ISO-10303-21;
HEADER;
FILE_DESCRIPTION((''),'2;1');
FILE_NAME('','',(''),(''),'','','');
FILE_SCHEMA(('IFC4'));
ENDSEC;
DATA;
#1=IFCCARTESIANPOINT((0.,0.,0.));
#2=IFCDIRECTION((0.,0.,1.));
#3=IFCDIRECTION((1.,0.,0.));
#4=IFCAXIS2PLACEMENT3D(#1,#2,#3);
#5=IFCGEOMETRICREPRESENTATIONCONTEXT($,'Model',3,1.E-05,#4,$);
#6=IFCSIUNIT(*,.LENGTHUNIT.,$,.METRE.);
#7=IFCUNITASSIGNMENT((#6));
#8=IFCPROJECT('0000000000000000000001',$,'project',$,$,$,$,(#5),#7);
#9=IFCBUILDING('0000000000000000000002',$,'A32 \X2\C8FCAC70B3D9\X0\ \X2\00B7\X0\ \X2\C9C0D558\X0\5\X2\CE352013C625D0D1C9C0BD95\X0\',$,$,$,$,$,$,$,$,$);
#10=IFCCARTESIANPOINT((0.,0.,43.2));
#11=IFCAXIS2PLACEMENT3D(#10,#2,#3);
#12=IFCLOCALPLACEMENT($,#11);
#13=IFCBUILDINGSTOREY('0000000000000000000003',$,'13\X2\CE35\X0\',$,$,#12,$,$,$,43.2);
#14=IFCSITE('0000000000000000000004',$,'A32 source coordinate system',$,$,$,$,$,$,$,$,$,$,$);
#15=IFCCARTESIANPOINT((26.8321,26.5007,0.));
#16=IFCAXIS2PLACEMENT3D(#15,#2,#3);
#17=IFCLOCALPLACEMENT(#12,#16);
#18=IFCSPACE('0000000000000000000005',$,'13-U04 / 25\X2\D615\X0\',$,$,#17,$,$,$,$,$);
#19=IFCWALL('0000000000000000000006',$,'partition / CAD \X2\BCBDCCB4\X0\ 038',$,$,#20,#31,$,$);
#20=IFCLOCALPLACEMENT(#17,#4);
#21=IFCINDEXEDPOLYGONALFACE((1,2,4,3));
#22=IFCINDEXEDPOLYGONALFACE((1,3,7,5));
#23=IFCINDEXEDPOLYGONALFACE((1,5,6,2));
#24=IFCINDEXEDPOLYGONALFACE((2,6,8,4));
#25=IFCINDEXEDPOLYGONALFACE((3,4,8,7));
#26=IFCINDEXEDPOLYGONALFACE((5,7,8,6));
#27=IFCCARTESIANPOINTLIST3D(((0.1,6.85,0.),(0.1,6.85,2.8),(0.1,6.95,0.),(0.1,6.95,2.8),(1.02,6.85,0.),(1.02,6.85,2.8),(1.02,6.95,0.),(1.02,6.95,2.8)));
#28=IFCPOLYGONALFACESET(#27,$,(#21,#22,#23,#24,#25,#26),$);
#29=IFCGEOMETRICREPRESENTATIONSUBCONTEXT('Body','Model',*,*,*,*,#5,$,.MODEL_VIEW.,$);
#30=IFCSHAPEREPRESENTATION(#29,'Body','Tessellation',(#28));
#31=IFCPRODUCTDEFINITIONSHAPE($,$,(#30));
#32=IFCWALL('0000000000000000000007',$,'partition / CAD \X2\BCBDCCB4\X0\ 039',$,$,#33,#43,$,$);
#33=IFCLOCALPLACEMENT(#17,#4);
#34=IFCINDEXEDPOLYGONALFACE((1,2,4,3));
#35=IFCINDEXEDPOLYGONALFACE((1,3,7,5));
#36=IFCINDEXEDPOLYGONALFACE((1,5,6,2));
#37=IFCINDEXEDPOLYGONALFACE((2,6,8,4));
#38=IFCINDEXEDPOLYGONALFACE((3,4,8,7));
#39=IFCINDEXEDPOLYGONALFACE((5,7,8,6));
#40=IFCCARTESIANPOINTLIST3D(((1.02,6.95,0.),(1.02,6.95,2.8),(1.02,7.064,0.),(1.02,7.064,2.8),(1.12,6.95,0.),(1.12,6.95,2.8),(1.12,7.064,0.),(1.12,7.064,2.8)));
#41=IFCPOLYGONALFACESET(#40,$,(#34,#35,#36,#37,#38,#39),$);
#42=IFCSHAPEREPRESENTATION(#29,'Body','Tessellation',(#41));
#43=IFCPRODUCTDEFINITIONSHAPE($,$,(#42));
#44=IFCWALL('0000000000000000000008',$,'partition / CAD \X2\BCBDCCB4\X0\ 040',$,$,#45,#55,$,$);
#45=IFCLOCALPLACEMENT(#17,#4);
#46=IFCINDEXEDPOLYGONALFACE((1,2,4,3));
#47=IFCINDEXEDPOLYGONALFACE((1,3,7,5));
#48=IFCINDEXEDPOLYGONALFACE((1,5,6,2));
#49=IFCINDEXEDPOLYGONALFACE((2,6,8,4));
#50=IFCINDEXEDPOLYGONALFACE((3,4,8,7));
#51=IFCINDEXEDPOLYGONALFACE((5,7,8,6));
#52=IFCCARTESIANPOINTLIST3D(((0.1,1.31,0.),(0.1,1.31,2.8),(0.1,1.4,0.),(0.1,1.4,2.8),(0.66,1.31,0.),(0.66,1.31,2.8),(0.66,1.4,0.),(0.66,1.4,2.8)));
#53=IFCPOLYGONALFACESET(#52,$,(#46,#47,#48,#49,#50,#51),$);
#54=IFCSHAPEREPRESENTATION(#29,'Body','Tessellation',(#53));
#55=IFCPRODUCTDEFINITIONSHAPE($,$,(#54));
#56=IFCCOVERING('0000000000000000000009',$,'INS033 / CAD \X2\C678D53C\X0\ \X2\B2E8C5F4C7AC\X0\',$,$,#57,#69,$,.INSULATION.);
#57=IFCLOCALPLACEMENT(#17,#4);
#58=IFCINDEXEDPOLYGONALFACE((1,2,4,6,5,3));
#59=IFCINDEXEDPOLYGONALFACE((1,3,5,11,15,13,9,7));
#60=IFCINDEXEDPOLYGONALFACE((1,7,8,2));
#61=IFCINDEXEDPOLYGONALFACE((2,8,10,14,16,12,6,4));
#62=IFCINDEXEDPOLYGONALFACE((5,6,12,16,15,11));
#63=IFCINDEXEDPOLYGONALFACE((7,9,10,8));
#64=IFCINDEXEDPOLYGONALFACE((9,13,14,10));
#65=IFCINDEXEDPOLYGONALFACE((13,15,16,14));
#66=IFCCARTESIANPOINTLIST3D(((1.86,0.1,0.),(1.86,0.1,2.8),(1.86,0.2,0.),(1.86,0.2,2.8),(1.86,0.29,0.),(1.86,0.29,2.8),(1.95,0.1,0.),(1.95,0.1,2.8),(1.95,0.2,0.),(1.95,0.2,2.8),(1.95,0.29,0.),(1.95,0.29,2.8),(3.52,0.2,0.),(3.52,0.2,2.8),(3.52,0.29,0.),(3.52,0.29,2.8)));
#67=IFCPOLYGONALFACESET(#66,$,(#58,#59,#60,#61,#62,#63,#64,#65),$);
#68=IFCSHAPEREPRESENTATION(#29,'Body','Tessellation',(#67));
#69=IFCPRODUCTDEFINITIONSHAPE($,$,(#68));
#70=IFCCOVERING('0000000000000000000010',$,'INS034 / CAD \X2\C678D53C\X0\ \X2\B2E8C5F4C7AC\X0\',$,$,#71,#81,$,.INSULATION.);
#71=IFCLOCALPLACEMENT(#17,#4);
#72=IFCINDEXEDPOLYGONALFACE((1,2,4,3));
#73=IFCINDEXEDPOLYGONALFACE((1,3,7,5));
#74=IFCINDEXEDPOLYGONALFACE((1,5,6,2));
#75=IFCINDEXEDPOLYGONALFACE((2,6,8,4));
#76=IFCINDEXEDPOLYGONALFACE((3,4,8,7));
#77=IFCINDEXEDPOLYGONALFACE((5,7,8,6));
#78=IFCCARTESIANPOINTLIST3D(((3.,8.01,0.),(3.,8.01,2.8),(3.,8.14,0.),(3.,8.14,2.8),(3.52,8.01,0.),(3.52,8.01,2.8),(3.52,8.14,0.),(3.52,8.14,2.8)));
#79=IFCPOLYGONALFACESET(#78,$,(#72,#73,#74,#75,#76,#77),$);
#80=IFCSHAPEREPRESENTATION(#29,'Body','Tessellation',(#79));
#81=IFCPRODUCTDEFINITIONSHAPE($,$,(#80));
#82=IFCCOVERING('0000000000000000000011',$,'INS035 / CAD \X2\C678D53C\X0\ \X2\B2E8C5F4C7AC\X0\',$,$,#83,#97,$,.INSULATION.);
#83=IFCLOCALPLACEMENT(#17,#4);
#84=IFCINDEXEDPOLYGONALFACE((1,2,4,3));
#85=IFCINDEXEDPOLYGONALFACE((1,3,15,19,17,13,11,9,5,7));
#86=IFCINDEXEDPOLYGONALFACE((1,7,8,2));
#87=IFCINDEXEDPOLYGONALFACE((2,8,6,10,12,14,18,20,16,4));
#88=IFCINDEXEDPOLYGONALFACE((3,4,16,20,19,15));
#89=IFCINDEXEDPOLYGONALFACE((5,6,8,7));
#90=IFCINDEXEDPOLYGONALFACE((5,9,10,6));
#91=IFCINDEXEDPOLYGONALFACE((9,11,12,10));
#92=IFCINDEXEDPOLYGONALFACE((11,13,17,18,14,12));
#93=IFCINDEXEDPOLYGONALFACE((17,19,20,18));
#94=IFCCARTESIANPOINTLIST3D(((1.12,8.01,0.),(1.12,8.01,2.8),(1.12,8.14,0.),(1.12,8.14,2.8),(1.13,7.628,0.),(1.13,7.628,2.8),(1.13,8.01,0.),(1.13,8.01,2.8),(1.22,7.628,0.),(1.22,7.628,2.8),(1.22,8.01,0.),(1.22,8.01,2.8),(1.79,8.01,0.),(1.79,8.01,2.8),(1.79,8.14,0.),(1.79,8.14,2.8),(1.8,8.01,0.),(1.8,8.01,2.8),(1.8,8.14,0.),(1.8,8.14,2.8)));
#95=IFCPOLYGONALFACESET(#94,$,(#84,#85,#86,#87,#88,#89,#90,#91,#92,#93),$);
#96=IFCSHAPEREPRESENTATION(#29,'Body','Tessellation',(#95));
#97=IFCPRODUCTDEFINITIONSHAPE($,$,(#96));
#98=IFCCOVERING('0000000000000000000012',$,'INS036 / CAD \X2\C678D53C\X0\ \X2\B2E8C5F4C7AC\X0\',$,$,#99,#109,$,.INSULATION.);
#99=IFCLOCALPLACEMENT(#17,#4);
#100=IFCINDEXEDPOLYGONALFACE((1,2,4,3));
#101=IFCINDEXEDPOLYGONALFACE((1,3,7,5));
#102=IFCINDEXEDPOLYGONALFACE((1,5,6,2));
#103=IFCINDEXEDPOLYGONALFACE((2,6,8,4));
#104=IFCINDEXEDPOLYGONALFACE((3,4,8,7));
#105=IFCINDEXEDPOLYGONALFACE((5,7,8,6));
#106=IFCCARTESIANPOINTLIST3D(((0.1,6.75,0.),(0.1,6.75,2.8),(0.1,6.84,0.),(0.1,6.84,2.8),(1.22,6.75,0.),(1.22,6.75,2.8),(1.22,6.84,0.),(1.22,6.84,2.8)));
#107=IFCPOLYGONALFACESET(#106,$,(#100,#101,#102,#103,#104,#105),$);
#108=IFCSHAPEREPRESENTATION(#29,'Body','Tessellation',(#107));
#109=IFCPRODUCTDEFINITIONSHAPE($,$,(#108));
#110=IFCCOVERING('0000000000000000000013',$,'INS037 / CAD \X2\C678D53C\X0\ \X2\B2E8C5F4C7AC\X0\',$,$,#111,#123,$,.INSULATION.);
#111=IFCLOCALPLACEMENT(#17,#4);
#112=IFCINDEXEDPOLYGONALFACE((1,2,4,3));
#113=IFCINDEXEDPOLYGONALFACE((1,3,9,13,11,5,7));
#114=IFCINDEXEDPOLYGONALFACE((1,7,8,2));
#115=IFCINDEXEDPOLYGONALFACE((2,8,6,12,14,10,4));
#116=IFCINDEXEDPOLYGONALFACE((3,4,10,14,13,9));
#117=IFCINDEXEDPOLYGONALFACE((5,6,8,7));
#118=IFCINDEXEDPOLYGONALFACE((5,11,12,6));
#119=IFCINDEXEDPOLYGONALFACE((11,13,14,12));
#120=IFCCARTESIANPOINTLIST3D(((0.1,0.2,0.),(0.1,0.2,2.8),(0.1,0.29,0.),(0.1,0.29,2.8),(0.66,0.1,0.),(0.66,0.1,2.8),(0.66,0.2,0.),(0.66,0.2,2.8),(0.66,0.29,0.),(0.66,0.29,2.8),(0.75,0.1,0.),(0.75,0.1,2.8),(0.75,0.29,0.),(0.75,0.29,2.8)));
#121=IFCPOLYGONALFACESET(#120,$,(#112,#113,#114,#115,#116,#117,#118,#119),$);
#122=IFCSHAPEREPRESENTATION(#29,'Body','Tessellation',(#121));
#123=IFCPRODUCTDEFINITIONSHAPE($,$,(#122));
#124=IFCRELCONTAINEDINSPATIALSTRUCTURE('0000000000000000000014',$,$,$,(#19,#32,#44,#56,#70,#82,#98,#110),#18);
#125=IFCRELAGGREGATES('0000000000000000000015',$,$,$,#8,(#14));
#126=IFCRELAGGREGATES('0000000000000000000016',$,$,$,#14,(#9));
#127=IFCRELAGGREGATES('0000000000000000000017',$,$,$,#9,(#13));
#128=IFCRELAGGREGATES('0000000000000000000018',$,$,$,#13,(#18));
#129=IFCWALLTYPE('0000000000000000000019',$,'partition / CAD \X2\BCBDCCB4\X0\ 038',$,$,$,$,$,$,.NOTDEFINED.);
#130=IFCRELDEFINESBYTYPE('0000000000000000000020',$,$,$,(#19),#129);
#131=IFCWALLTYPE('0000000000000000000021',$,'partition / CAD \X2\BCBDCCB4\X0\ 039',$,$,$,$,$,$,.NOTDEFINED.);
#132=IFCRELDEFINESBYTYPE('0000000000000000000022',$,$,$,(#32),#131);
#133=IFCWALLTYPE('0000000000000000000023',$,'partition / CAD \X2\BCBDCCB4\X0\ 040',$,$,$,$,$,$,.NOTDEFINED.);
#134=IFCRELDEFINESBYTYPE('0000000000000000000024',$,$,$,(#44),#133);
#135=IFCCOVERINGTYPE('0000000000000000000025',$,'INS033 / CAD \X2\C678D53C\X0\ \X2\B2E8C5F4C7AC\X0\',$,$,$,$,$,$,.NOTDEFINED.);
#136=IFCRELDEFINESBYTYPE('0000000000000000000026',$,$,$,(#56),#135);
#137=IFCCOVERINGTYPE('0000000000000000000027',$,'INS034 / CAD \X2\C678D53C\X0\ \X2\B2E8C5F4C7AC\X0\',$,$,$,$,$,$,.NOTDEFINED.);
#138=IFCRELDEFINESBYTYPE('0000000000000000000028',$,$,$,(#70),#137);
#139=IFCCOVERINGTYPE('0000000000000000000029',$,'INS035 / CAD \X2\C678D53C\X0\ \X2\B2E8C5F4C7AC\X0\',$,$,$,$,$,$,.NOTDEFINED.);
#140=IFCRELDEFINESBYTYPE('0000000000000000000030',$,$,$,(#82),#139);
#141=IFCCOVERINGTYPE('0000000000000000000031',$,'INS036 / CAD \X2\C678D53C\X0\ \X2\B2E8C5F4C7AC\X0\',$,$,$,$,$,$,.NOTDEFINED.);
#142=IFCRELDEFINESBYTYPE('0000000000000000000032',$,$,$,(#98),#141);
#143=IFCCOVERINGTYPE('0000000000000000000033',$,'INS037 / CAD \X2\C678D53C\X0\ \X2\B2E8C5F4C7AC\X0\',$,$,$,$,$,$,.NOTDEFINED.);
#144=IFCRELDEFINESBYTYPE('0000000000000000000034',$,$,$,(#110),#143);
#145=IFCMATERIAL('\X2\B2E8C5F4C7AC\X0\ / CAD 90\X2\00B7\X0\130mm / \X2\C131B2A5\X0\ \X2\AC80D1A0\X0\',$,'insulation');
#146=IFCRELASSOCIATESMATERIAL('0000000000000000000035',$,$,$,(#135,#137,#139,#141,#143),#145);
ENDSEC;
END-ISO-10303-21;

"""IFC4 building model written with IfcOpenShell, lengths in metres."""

from ifc_helpers import new_model, si_unit, frame, origin, origin_with_axes, place, context, subcontext, project, spatial, polyline, outline, extrude, source, transform, mapped, material, type_object, type_shapes, element, save


model = new_model("IFC4")

# Units and contexts
model_context = context("Model", 3, precision=1e-05, world=origin_with_axes())
body_context = subcontext(model_context, "Body", "Model", "MODEL_VIEW")
ifc_project = project(units=[si_unit("LENGTHUNIT", "METRE")], contexts=[model_context])

# Site, building, storey, space
storey_placement = place(None, frame((0.0, 0.0, 43.2), z_axis=(0.0, 0.0, 1.0), x_axis=(1.0, 0.0, 0.0)))
space_placement = place(storey_placement, frame((26.8321, 26.5007, 0.0), z_axis=(0.0, 0.0, 1.0), x_axis=(1.0, 0.0, 0.0)))
site = spatial("IfcSite", under=ifc_project, Name="A32 source coordinate system")
building = spatial("IfcBuilding", under=site, Name="A32 주거동 · 지하5층–옥탑지붕")
storey = spatial("IfcBuildingStorey", under=building, at=storey_placement, Name="13층", Elevation=43.2)
space = spatial("IfcSpace", under=storey, at=space_placement, Name="13-U04 / 25형")

# Walls
wall_type_1 = type_object("IfcWallType", Name="partition / CAD 벽체 038", PredefinedType="NOTDEFINED")
shared_shape_1 = source(origin(), body_context, "Body", "SweptSolid", [
    extrude(outline(polyline([(0.1, 6.95), (1.02, 6.95), (1.02, 6.85), (0.1, 6.85), (0.1, 6.95)])), origin(), (0.0, 0.0, 1.0), 2.8),
])
type_shapes(wall_type_1, [shared_shape_1])
wall_1_placement = place(space_placement, origin_with_axes())
element("IfcWall", 1, at=wall_1_placement, inside=space, type_object=wall_type_1, Name="partition / CAD 벽체 038", context=body_context, shape_type="MappedRepresentation", body=[
    mapped(shared_shape_1, transform((0.0, 0.0, 0.0), scale=1.0)),
])
wall_type_2 = type_object("IfcWallType", Name="partition / CAD 벽체 039", PredefinedType="NOTDEFINED")
shared_shape_2 = source(origin(), body_context, "Body", "SweptSolid", [
    extrude(outline(polyline([(1.02, 6.95), (1.02, 7.064), (1.12, 7.064), (1.12, 6.95), (1.02, 6.95)])), origin(), (0.0, 0.0, 1.0), 2.8),
])
type_shapes(wall_type_2, [shared_shape_2])
wall_2_placement = place(space_placement, origin_with_axes())
element("IfcWall", 2, at=wall_2_placement, inside=space, type_object=wall_type_2, Name="partition / CAD 벽체 039", context=body_context, shape_type="MappedRepresentation", body=[
    mapped(shared_shape_2, transform((0.0, 0.0, 0.0), scale=1.0)),
])
wall_type_3 = type_object("IfcWallType", Name="partition / CAD 벽체 040", PredefinedType="NOTDEFINED")
shared_shape_3 = source(origin(), body_context, "Body", "SweptSolid", [
    extrude(outline(polyline([(0.1, 1.4), (0.66, 1.4), (0.66, 1.31), (0.1, 1.31), (0.1, 1.4)])), origin(), (0.0, 0.0, 1.0), 2.8),
])
type_shapes(wall_type_3, [shared_shape_3])
wall_3_placement = place(space_placement, origin_with_axes())
element("IfcWall", 3, at=wall_3_placement, inside=space, type_object=wall_type_3, Name="partition / CAD 벽체 040", context=body_context, shape_type="MappedRepresentation", body=[
    mapped(shared_shape_3, transform((0.0, 0.0, 0.0), scale=1.0)),
])

# Coverings
ifc_material = material(Name="단열재 / CAD 90·130mm / 성능 검토", Category="insulation")
covering_type_1 = type_object("IfcCoveringType", Name="INS033 / CAD 외피 단열재", PredefinedType="NOTDEFINED", material=ifc_material)
shared_shape_4 = source(origin(), body_context, "Body", "SweptSolid", [
    extrude(outline(polyline([(1.95, 0.29), (3.52, 0.29), (3.52, 0.2), (1.95, 0.2), (1.95, 0.1), (1.86, 0.1), (1.86, 0.2), (1.86, 0.29), (1.95, 0.29)])), origin(), (0.0, 0.0, 1.0), 2.8),
])
type_shapes(covering_type_1, [shared_shape_4])
covering_1_placement = place(space_placement, origin_with_axes())
element("IfcCovering", 4, at=covering_1_placement, inside=space, type_object=covering_type_1, Name="INS033 / CAD 외피 단열재", PredefinedType="INSULATION", context=body_context, shape_type="MappedRepresentation", body=[
    mapped(shared_shape_4, transform((0.0, 0.0, 0.0), scale=1.0)),
])
covering_type_2 = type_object("IfcCoveringType", Name="INS034 / CAD 외피 단열재", PredefinedType="NOTDEFINED", material=ifc_material)
shared_shape_5 = source(origin(), body_context, "Body", "SweptSolid", [
    extrude(outline(polyline([(3.52, 8.01), (3.0, 8.01), (3.0, 8.14), (3.52, 8.14), (3.52, 8.01)])), origin(), (0.0, 0.0, 1.0), 2.8),
])
type_shapes(covering_type_2, [shared_shape_5])
covering_2_placement = place(space_placement, origin_with_axes())
element("IfcCovering", 5, at=covering_2_placement, inside=space, type_object=covering_type_2, Name="INS034 / CAD 외피 단열재", PredefinedType="INSULATION", context=body_context, shape_type="MappedRepresentation", body=[
    mapped(shared_shape_5, transform((0.0, 0.0, 0.0), scale=1.0)),
])
covering_type_3 = type_object("IfcCoveringType", Name="INS035 / CAD 외피 단열재", PredefinedType="NOTDEFINED", material=ifc_material)
shared_shape_6 = source(origin(), body_context, "Body", "SweptSolid", [
    extrude(outline(polyline([(1.8, 8.01), (1.79, 8.01), (1.22, 8.01), (1.22, 7.628), (1.13, 7.628), (1.13, 8.01), (1.12, 8.01), (1.12, 8.14), (1.79, 8.14), (1.8, 8.14), (1.8, 8.01)])), origin(), (0.0, 0.0, 1.0), 2.8),
])
type_shapes(covering_type_3, [shared_shape_6])
covering_3_placement = place(space_placement, origin_with_axes())
element("IfcCovering", 6, at=covering_3_placement, inside=space, type_object=covering_type_3, Name="INS035 / CAD 외피 단열재", PredefinedType="INSULATION", context=body_context, shape_type="MappedRepresentation", body=[
    mapped(shared_shape_6, transform((0.0, 0.0, 0.0), scale=1.0)),
])
covering_type_4 = type_object("IfcCoveringType", Name="INS036 / CAD 외피 단열재", PredefinedType="NOTDEFINED", material=ifc_material)
shared_shape_7 = source(origin(), body_context, "Body", "SweptSolid", [
    extrude(outline(polyline([(1.22, 6.84), (1.22, 6.75), (0.1, 6.75), (0.1, 6.84), (1.22, 6.84)])), origin(), (0.0, 0.0, 1.0), 2.8),
])
type_shapes(covering_type_4, [shared_shape_7])
covering_4_placement = place(space_placement, origin_with_axes())
element("IfcCovering", 7, at=covering_4_placement, inside=space, type_object=covering_type_4, Name="INS036 / CAD 외피 단열재", PredefinedType="INSULATION", context=body_context, shape_type="MappedRepresentation", body=[
    mapped(shared_shape_7, transform((0.0, 0.0, 0.0), scale=1.0)),
])
covering_type_5 = type_object("IfcCoveringType", Name="INS037 / CAD 외피 단열재", PredefinedType="NOTDEFINED", material=ifc_material)
shared_shape_8 = source(origin(), body_context, "Body", "SweptSolid", [
    extrude(outline(polyline([(0.1, 0.2), (0.1, 0.29), (0.66, 0.29), (0.75, 0.29), (0.75, 0.1), (0.66, 0.1), (0.66, 0.2), (0.1, 0.2)])), origin(), (0.0, 0.0, 1.0), 2.8),
])
type_shapes(covering_type_5, [shared_shape_8])
covering_5_placement = place(space_placement, origin_with_axes())
element("IfcCovering", 8, at=covering_5_placement, inside=space, type_object=covering_type_5, Name="INS037 / CAD 외피 단열재", PredefinedType="INSULATION", context=body_context, shape_type="MappedRepresentation", body=[
    mapped(shared_shape_8, transform((0.0, 0.0, 0.0), scale=1.0)),
])

save(model, "model.ifc")
